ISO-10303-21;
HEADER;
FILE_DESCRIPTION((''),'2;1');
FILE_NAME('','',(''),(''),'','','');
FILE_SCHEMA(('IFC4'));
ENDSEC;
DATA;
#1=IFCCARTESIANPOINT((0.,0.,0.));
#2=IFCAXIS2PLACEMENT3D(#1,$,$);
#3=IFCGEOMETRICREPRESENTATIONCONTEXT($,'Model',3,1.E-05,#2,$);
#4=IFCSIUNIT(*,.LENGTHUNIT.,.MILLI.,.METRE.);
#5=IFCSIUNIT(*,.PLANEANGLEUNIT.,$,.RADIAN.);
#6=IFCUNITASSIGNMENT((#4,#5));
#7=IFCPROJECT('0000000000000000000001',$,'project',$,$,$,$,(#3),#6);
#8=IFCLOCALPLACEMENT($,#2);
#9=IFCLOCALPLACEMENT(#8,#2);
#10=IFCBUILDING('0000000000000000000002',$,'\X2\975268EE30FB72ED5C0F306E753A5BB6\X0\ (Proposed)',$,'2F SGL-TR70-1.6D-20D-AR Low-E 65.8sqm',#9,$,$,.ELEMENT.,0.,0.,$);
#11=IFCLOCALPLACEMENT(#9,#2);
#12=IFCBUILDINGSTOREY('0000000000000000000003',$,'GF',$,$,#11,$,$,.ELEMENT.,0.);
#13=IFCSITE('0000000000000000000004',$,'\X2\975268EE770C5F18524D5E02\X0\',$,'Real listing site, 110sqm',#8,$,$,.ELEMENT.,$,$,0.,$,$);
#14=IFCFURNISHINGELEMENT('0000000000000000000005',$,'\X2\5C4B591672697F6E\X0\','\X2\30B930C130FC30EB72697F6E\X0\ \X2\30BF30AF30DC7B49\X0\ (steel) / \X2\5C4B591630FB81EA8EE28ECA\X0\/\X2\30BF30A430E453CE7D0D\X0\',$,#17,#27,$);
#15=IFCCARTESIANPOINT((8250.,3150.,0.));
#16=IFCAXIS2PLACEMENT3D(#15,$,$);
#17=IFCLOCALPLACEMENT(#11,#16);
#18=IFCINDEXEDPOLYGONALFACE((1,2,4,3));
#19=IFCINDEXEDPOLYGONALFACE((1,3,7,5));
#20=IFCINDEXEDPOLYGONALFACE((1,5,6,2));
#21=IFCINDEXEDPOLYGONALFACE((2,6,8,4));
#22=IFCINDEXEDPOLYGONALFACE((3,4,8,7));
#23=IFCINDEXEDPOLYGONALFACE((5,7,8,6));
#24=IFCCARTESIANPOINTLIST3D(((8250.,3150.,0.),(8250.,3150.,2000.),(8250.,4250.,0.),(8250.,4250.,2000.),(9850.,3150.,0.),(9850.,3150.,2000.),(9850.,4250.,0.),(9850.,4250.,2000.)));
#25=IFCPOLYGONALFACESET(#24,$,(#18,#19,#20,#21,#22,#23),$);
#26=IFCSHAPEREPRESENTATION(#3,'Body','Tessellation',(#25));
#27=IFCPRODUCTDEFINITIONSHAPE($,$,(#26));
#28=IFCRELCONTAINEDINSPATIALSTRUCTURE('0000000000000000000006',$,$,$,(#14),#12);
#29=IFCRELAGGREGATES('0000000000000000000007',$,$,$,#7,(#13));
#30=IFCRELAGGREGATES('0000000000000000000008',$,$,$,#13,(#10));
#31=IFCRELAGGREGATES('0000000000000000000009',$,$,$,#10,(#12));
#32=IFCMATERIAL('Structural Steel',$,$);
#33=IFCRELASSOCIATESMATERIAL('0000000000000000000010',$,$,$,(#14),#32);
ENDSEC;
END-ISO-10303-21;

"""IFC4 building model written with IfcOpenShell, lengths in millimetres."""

from ifc_helpers import new_model, si_unit, frame, frame_2d, origin, place, context, project, spatial, rectangle, extrude, material, element, save


model = new_model("IFC4")

# Units and contexts
model_context = context("Model", 3, precision=1e-05, world=origin())
ifc_project = project(units=[si_unit("LENGTHUNIT", "METRE", prefix="MILLI"), si_unit("PLANEANGLEUNIT", "RADIAN")], contexts=[model_context])

# Site, building, storey
site_placement = place(None, origin())
site = spatial("IfcSite", under=ifc_project, at=site_placement, Name="青森県弘前市", ObjectType="Real listing site, 110sqm", CompositionType="ELEMENT", RefElevation=0.0)
building_placement = place(site_placement, origin())
building = spatial("IfcBuilding", under=site, at=building_placement, Name="青森・狭小の町家 (Proposed)", ObjectType="2F SGL-TR70-1.6D-20D-AR Low-E 65.8sqm", CompositionType="ELEMENT", ElevationOfRefHeight=0.0, ElevationOfTerrain=0.0)
storey_placement = place(building_placement, origin())
storey = spatial("IfcBuildingStorey", under=building, at=storey_placement, Name="GF", CompositionType="ELEMENT", Elevation=0.0)

# Shared definitions
ifc_material_1 = material(Name="Structural Steel")

# Furnishing element
furnishing_1_placement = place(storey_placement, frame((8250.0, 3150.0, 0.0)))
element("IfcFurnishingElement", 1, at=furnishing_1_placement, inside=storey, material=ifc_material_1, Name="屋外物置", Description="スチール物置 タクボ等 (steel) / 屋外・自転車/タイヤ収納", context=model_context, shape_type="SweptSolid", body=[
    extrude(rectangle(XDim=1600.0, YDim=1100.0, at=frame_2d((800.0, 550.0))), frame((8250.0, 3150.0, 0.0)), (0.0, 0.0, 1.0), 2000.0),
])

save(model, "model.ifc")
